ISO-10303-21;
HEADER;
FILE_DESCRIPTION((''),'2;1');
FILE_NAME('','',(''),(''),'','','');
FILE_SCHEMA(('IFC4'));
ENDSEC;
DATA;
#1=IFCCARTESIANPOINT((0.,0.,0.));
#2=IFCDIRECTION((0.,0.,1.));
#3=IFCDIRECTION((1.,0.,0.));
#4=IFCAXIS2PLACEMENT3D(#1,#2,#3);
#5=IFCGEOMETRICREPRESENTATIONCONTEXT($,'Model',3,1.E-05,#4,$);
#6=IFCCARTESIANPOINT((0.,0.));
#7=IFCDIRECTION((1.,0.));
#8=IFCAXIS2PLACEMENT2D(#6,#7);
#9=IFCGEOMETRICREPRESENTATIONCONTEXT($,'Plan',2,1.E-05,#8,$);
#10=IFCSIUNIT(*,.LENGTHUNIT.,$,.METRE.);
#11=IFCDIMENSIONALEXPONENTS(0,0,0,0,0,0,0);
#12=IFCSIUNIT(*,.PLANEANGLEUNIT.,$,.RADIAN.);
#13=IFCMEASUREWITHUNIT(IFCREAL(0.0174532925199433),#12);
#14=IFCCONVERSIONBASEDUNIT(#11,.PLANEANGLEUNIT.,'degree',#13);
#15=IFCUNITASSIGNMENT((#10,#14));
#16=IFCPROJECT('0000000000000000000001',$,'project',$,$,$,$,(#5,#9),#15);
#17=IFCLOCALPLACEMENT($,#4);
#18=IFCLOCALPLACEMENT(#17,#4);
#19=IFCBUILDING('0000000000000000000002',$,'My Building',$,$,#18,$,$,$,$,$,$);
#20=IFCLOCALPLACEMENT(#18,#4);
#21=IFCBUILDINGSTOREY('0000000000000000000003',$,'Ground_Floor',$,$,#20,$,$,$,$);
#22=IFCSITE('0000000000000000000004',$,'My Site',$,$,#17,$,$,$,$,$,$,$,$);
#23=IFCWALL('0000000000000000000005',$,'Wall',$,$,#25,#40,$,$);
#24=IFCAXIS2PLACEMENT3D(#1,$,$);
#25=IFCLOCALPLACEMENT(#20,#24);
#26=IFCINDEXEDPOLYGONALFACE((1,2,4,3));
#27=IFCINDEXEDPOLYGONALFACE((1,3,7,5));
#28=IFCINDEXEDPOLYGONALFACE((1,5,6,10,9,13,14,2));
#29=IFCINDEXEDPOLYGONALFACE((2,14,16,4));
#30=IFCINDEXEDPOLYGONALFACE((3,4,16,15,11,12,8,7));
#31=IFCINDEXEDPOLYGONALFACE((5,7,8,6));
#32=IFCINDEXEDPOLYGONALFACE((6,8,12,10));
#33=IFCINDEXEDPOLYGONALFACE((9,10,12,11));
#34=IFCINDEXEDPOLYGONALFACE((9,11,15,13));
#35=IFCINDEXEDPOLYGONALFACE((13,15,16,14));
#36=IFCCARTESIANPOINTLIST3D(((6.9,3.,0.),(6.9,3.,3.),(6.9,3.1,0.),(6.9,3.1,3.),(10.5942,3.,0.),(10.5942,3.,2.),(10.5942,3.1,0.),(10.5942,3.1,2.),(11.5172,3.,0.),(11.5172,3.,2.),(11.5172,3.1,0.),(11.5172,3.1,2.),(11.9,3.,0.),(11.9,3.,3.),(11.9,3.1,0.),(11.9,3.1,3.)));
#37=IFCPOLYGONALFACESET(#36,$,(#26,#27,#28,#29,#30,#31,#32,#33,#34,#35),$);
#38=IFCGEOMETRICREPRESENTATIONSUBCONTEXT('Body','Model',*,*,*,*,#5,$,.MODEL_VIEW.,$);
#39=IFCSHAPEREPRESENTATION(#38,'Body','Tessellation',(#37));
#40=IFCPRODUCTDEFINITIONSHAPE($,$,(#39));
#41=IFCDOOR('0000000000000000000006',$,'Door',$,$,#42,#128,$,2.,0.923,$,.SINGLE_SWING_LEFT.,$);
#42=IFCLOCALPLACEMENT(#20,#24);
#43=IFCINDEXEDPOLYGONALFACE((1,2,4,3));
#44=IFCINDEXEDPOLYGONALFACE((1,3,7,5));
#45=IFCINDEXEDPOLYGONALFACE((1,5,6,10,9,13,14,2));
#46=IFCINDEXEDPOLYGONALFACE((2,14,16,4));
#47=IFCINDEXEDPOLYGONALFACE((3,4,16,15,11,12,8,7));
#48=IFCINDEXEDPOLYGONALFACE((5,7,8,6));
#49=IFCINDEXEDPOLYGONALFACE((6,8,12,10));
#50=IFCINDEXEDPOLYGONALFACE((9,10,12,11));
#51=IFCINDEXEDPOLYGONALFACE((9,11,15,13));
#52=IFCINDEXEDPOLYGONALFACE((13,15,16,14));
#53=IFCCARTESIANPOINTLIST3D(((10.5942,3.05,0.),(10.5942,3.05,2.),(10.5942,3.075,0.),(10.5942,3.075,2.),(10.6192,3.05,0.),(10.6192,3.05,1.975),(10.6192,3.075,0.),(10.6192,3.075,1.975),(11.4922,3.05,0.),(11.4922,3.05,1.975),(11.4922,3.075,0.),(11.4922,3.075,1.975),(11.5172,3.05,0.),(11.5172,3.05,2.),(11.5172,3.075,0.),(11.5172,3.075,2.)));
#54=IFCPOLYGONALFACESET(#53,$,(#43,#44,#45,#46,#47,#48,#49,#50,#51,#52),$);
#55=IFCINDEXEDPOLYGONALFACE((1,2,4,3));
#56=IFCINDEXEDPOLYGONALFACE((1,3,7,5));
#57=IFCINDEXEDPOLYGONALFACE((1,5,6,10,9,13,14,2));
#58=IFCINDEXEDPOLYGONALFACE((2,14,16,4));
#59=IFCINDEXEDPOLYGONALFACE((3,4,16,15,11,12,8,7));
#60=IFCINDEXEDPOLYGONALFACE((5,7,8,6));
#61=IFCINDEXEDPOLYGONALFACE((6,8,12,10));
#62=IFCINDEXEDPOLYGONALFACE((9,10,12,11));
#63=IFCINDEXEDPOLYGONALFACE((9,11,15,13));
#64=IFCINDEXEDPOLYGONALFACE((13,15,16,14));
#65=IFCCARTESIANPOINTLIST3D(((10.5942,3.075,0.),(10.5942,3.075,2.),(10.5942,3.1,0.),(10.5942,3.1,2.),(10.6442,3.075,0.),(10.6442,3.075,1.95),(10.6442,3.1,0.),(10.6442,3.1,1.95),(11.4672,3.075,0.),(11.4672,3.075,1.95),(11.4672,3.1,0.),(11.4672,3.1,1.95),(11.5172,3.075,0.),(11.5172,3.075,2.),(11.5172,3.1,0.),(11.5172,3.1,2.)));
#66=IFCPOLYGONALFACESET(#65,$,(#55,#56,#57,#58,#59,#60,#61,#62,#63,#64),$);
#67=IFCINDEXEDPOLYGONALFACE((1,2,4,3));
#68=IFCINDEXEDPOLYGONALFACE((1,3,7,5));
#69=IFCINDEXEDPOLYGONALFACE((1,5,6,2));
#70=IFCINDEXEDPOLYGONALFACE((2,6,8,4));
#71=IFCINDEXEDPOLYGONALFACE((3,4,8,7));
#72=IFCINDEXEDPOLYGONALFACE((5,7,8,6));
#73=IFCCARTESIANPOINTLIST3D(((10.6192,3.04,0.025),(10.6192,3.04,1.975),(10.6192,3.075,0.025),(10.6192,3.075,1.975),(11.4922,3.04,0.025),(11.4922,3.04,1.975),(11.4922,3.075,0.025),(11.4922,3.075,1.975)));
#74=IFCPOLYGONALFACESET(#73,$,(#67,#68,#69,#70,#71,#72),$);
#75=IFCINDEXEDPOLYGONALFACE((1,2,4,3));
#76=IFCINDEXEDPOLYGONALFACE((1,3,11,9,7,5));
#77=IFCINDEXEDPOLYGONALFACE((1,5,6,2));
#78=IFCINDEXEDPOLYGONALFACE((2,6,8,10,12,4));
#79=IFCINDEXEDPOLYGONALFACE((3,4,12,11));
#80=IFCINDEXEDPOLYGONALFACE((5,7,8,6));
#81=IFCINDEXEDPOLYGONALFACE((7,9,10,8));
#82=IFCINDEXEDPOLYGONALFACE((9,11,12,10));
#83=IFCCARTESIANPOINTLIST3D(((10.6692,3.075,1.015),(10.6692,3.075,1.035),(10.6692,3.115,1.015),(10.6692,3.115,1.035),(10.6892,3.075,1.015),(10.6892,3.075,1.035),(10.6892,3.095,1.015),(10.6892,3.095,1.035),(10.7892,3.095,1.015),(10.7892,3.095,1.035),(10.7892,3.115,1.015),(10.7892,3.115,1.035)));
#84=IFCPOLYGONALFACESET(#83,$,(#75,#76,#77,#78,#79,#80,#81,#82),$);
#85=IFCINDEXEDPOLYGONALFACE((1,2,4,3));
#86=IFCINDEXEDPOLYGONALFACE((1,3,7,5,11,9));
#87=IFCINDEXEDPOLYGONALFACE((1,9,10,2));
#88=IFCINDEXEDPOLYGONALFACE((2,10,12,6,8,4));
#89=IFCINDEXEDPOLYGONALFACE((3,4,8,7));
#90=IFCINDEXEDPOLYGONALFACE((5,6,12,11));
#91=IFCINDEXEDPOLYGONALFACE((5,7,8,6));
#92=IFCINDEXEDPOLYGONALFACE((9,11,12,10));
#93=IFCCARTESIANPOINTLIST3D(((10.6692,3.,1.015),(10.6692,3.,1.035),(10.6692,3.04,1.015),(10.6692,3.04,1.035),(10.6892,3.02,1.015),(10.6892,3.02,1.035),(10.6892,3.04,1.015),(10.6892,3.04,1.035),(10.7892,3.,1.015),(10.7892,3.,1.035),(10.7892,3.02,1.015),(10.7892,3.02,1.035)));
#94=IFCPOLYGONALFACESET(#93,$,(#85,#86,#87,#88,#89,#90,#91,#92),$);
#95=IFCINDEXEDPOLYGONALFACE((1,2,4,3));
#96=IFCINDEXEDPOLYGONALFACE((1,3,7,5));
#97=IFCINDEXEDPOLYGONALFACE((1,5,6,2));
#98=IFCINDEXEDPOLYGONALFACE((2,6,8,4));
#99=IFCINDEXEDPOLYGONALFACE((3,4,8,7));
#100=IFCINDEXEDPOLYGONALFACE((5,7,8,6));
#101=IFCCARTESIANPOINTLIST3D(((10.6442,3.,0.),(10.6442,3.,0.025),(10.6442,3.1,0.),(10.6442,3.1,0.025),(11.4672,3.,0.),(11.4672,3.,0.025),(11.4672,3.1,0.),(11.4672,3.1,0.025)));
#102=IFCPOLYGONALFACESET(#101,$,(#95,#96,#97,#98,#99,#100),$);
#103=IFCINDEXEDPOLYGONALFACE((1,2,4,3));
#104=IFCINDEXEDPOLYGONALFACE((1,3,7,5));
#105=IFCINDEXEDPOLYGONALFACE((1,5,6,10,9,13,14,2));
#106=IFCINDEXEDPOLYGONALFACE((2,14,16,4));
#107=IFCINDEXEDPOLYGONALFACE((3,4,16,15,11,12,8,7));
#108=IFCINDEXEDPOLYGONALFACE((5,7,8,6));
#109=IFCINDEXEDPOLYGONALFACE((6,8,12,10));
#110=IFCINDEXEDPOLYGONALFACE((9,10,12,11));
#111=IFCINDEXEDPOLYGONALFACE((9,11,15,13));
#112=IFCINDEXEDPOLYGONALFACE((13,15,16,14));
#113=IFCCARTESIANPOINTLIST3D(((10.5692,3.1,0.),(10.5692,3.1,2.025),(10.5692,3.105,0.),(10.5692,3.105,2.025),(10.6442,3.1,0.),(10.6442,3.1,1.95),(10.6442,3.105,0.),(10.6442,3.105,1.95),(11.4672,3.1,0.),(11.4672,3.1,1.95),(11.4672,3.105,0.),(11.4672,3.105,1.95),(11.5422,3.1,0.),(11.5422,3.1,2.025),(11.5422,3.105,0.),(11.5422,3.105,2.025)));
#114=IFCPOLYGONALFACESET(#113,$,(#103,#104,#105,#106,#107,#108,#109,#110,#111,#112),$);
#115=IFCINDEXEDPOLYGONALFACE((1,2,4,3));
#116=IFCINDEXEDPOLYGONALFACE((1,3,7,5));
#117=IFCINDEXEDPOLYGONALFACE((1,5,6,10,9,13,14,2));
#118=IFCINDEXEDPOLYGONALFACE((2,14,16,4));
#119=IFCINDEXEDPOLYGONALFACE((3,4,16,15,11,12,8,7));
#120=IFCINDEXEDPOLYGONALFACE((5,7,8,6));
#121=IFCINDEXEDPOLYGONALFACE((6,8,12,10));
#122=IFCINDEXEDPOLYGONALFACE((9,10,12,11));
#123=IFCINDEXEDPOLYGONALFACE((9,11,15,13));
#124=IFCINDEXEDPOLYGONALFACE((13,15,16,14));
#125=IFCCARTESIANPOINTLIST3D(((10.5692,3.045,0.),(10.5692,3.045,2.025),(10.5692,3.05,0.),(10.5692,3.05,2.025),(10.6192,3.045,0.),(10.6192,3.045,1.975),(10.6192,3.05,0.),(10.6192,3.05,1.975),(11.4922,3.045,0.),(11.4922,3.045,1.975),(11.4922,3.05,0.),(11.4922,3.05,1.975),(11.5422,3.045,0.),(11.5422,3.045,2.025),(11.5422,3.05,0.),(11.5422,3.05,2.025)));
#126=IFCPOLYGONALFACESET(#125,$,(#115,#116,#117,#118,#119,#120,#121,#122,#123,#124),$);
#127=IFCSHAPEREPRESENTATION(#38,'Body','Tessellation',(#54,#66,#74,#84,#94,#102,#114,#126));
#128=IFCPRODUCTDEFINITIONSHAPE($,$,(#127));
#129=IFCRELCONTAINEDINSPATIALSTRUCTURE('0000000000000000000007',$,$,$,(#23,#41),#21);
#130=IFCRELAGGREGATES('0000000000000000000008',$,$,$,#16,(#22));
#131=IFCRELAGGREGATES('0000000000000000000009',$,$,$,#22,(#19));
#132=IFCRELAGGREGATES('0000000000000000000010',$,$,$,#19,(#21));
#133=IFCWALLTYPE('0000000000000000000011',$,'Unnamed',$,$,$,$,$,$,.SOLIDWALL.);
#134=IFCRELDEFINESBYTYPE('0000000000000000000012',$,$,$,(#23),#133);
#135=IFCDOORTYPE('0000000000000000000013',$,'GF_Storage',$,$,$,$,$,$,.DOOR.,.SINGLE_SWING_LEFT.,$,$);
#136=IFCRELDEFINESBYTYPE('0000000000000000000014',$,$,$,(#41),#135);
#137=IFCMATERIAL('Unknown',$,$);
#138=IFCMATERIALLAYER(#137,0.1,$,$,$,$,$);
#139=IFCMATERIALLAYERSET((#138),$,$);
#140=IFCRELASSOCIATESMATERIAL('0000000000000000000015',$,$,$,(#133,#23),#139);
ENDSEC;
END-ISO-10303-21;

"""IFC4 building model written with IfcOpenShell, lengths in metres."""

from ifc_helpers import new_model, entity, si_unit, converted_unit, frame, origin_with_axes, origin_2d_with_axis, place, context, subcontext, project, spatial, line, indexed_curve, outline, extrude, shape, source, transform, mapped, material, layer, layer_set, layer_usage, type_object, type_shapes, element, fill, save


model = new_model("IFC4")

# Units and contexts
model_context = context("Model", 3, precision=1e-05, world=origin_with_axes())
plan_context = context("Plan", 2, precision=1e-05, world=origin_2d_with_axis())
body_context_1 = subcontext(model_context, "Body", "Model", "MODEL_VIEW")
body_context_2 = subcontext(plan_context, "Body", "Plan", "PLAN_VIEW")
ifc_project = project(units=[si_unit("LENGTHUNIT", "METRE"), converted_unit("PLANEANGLEUNIT", "degree", entity("IfcReal", 0.0174532925199433), si_unit("PLANEANGLEUNIT", "RADIAN"), dimensions=[0, 0, 0, 0, 0, 0, 0])], contexts=[model_context, plan_context])

# Site, building, storey
site_placement = place(None, origin_with_axes())
site = spatial("IfcSite", under=ifc_project, at=site_placement, Name="My Site")
building_placement = place(site_placement, origin_with_axes())
building = spatial("IfcBuilding", under=site, at=building_placement, Name="My Building")
storey_placement = place(building_placement, origin_with_axes())
storey = spatial("IfcBuildingStorey", under=building, at=storey_placement, Name="Ground_Floor")

# Shared definitions
ifc_material = material(Name="Unknown")
ifc_layer = layer(ifc_material, 0.1)
ifc_layer_set = layer_set([ifc_layer])
wall_type = type_object("IfcWallType", Name="Unnamed", PredefinedType="SOLIDWALL", material=ifc_layer_set)

# Wall, opening, door
ifc_layer_usage_1 = layer_usage(ifc_layer_set, "AXIS2", "POSITIVE", 0.0)
wall_1_placement = place(storey_placement, frame((11.9, 3.1, 0.0), z_axis=(0.0, 0.0, 1.0), x_axis=(-1.0, 0.0, 0.0)))
wall_1 = element("IfcWall", 1, at=wall_1_placement, inside=storey, type_object=wall_type, material=ifc_layer_usage_1, Name="Wall", context=body_context_1, shape_type="SweptSolid", body=[
    extrude(outline(indexed_curve([(0.0, 0.0), (0.0, 0.1), (5.0, 0.1), (5.0, 0.0)], segments=[line(1, 2, 3, 4, 1)])), origin_with_axes(), (0.0, 0.0, 1.0), 3.0),
])
shared_shape_1 = source(origin_with_axes(), body_context_1, "Body", "SweptSolid", [
    extrude(outline(indexed_curve([(0.0, 0.0), (0.923, 0.0), (0.923, 2.0), (0.0, 2.0)], segments=[line(1, 2, 3, 4, 1)])), frame((0.0, -0.6, 0.0), z_axis=(0.0, -1.0, 0.0), x_axis=(1.0, 0.0, 0.0)), (0.0, 0.0, -1.0), 1.2),
])
opening_1_placement = place(wall_1_placement, frame((0.3828, 0.0, 0.0), z_axis=(0.0, 0.0, 1.0), x_axis=(1.0, 0.0, 0.0)))
opening_1 = element("IfcOpeningElement", 2, at=opening_1_placement, cuts=wall_1, PredefinedType="OPENING", context=body_context_1, shape_type="MappedRepresentation", body=[
    mapped(shared_shape_1, transform((0.0, 0.0, 0.0), x_axis=(1.0, 0.0, 0.0), y_axis=(0.0, 1.0, 0.0), z_axis=(0.0, 0.0, 1.0), scale=1.0)),
])
door_type_1 = type_object("IfcDoorType", Name="GF_Storage", OperationType="SINGLE_SWING_LEFT", PredefinedType="DOOR")
shared_shape_2 = source(origin_with_axes(), body_context_1, "Body", "SweptSolid", [
    extrude(outline(indexed_curve([(0.0, 0.0), (0.0, 2.0), (0.923, 2.0), (0.923, 0.0), (0.898, 0.0), (0.898, 1.975), (0.025, 1.975), (0.025, 0.0)], segments=[line(1, 2, 3, 4, 5, 6, 7, 8, 1)])), frame((0.0, 0.025, 0.0), z_axis=(0.0, -1.0, 0.0), x_axis=(1.0, 0.0, 0.0)), (0.0, 0.0, -1.0), 0.025),
    extrude(outline(indexed_curve([(0.0, 0.0), (0.0, 2.0), (0.923, 2.0), (0.923, 0.0), (0.873, 0.0), (0.873, 1.95), (0.05, 1.95), (0.05, 0.0)], segments=[line(1, 2, 3, 4, 5, 6, 7, 8, 1)])), frame((0.0, 0.0, 0.0), z_axis=(0.0, -1.0, 0.0), x_axis=(1.0, 0.0, 0.0)), (0.0, 0.0, -1.0), 0.025),
    extrude(outline(indexed_curve([(0.0, 0.0), (0.873, 0.0), (0.873, 0.035), (0.0, 0.035)], segments=[line(1, 2, 3, 4, 1)])), frame((0.025, 0.025, 0.025), z_axis=(0.0, 0.0, 1.0), x_axis=(1.0, 0.0, 0.0)), (0.0, 0.0, 1.0), 1.95),
    extrude(outline(indexed_curve([(0.0, 0.0), (0.0, -0.04), (-0.12, -0.04), (-0.12, -0.02), (-0.02, -0.02), (-0.02, 0.0)], segments=[line(1, 2, 3, 4, 5, 6, 1)])), frame((0.848, 0.025, 1.015), z_axis=(0.0, 0.0, 1.0), x_axis=(1.0, 0.0, 0.0)), (0.0, 0.0, 1.0), 0.02),
    extrude(outline(indexed_curve([(0.0, 0.0), (0.0, 0.04), (-0.12, 0.04), (-0.12, 0.02), (-0.02, 0.02), (-0.02, 0.0)], segments=[line(1, 2, 3, 4, 5, 6, 1)])), frame((0.848, 0.06, 1.015), z_axis=(0.0, 0.0, 1.0), x_axis=(1.0, 0.0, 0.0)), (0.0, 0.0, 1.0), 0.02),
    extrude(outline(indexed_curve([(0.0, 0.0), (0.823, 0.0), (0.823, 0.1), (0.0, 0.1)], segments=[line(1, 2, 3, 4, 1)])), frame((0.05, 0.0, 0.0), z_axis=(0.0, 0.0, 1.0), x_axis=(1.0, 0.0, 0.0)), (0.0, 0.0, 1.0), 0.025),
    extrude(outline(indexed_curve([(0.0, 0.0), (0.0, 2.025), (0.973, 2.025), (0.973, 0.0), (0.898, 0.0), (0.898, 1.95), (0.075, 1.95), (0.075, 0.0)], segments=[line(1, 2, 3, 4, 5, 6, 7, 8, 1)])), frame((-0.025, -0.005, 0.0), z_axis=(0.0, -1.0, 0.0), x_axis=(1.0, 0.0, 0.0)), (0.0, 0.0, -1.0), 0.005),
    extrude(outline(indexed_curve([(0.0, 0.0), (0.0, 2.025), (0.973, 2.025), (0.973, 0.0), (0.923, 0.0), (0.923, 1.975), (0.05, 1.975), (0.05, 0.0)], segments=[line(1, 2, 3, 4, 5, 6, 7, 8, 1)])), frame((-0.025, 0.05, 0.0), z_axis=(0.0, -1.0, 0.0), x_axis=(1.0, 0.0, 0.0)), (0.0, 0.0, -1.0), 0.005),
])
shared_shape_3 = source(origin_with_axes(), body_context_2, "Body", "Curve2D", [
    entity("IfcIndexedPolyCurve", entity("IfcCartesianPointList2D", [[0.0, 0.0], [0.0, 0.05], [0.025, 0.05], [0.025, 0.025], [0.05, 0.025], [0.05, 0.0]]), [entity("IfcLineIndex", [1, 2, 3, 4, 5, 6, 1])]),
    entity("IfcIndexedPolyCurve", entity("IfcCartesianPointList2D", [[0.923, 0.0], [0.923, 0.05], [0.898, 0.05], [0.898, 0.025], [0.873, 0.025], [0.873, 0.0]]), [entity("IfcLineIndex", [1, 2, 3, 4, 5, 6, 1])]),
    entity("IfcTrimmedCurve", entity("IfcEllipse", entity("IfcAxis2Placement2D", entity("IfcCartesianPoint", [0.06, 0.05]), entity("IfcDirection", [1.0, 0.0])), 0.838, 0.873), [entity("IfcCartesianPoint", [0.898, 0.05])], [entity("IfcCartesianPoint", [0.06, 0.923])], True, "CARTESIAN"),
    entity("IfcIndexedPolyCurve", entity("IfcCartesianPointList2D", [[0.025, 0.05], [0.06, 0.05], [0.06, 0.923], [0.025, 0.923]]), [entity("IfcLineIndex", [1, 2, 3, 4, 1])]),
])
type_shapes(door_type_1, [shared_shape_2, shared_shape_3])
door_1_placement = place(opening_1_placement, frame((0.0, 0.0, 0.0), z_axis=(0.0, 0.0, 1.0), x_axis=(1.0, 0.0, 0.0)))
door_1 = element("IfcDoor", 3, at=door_1_placement, inside=storey, type_object=door_type_1, Name="Door", OperationType="SINGLE_SWING_LEFT", OverallHeight=2.0, OverallWidth=0.923, shapes=[
    shape(body_context_1, "Body", "MappedRepresentation", [mapped(shared_shape_2, transform((0.0, 0.0, 0.0), x_axis=(1.0, 0.0, 0.0), y_axis=(0.0, 1.0, 0.0), z_axis=(0.0, 0.0, 1.0), scale=1.0))]),
    shape(body_context_2, "Body", "MappedRepresentation", [mapped(shared_shape_3, transform((0.0, 0.0, 0.0), x_axis=(1.0, 0.0, 0.0), y_axis=(0.0, 1.0, 0.0), z_axis=(0.0, 0.0, 1.0), scale=1.0))]),
])
fill(opening_1, door_1)

save(model, "model.ifc")
